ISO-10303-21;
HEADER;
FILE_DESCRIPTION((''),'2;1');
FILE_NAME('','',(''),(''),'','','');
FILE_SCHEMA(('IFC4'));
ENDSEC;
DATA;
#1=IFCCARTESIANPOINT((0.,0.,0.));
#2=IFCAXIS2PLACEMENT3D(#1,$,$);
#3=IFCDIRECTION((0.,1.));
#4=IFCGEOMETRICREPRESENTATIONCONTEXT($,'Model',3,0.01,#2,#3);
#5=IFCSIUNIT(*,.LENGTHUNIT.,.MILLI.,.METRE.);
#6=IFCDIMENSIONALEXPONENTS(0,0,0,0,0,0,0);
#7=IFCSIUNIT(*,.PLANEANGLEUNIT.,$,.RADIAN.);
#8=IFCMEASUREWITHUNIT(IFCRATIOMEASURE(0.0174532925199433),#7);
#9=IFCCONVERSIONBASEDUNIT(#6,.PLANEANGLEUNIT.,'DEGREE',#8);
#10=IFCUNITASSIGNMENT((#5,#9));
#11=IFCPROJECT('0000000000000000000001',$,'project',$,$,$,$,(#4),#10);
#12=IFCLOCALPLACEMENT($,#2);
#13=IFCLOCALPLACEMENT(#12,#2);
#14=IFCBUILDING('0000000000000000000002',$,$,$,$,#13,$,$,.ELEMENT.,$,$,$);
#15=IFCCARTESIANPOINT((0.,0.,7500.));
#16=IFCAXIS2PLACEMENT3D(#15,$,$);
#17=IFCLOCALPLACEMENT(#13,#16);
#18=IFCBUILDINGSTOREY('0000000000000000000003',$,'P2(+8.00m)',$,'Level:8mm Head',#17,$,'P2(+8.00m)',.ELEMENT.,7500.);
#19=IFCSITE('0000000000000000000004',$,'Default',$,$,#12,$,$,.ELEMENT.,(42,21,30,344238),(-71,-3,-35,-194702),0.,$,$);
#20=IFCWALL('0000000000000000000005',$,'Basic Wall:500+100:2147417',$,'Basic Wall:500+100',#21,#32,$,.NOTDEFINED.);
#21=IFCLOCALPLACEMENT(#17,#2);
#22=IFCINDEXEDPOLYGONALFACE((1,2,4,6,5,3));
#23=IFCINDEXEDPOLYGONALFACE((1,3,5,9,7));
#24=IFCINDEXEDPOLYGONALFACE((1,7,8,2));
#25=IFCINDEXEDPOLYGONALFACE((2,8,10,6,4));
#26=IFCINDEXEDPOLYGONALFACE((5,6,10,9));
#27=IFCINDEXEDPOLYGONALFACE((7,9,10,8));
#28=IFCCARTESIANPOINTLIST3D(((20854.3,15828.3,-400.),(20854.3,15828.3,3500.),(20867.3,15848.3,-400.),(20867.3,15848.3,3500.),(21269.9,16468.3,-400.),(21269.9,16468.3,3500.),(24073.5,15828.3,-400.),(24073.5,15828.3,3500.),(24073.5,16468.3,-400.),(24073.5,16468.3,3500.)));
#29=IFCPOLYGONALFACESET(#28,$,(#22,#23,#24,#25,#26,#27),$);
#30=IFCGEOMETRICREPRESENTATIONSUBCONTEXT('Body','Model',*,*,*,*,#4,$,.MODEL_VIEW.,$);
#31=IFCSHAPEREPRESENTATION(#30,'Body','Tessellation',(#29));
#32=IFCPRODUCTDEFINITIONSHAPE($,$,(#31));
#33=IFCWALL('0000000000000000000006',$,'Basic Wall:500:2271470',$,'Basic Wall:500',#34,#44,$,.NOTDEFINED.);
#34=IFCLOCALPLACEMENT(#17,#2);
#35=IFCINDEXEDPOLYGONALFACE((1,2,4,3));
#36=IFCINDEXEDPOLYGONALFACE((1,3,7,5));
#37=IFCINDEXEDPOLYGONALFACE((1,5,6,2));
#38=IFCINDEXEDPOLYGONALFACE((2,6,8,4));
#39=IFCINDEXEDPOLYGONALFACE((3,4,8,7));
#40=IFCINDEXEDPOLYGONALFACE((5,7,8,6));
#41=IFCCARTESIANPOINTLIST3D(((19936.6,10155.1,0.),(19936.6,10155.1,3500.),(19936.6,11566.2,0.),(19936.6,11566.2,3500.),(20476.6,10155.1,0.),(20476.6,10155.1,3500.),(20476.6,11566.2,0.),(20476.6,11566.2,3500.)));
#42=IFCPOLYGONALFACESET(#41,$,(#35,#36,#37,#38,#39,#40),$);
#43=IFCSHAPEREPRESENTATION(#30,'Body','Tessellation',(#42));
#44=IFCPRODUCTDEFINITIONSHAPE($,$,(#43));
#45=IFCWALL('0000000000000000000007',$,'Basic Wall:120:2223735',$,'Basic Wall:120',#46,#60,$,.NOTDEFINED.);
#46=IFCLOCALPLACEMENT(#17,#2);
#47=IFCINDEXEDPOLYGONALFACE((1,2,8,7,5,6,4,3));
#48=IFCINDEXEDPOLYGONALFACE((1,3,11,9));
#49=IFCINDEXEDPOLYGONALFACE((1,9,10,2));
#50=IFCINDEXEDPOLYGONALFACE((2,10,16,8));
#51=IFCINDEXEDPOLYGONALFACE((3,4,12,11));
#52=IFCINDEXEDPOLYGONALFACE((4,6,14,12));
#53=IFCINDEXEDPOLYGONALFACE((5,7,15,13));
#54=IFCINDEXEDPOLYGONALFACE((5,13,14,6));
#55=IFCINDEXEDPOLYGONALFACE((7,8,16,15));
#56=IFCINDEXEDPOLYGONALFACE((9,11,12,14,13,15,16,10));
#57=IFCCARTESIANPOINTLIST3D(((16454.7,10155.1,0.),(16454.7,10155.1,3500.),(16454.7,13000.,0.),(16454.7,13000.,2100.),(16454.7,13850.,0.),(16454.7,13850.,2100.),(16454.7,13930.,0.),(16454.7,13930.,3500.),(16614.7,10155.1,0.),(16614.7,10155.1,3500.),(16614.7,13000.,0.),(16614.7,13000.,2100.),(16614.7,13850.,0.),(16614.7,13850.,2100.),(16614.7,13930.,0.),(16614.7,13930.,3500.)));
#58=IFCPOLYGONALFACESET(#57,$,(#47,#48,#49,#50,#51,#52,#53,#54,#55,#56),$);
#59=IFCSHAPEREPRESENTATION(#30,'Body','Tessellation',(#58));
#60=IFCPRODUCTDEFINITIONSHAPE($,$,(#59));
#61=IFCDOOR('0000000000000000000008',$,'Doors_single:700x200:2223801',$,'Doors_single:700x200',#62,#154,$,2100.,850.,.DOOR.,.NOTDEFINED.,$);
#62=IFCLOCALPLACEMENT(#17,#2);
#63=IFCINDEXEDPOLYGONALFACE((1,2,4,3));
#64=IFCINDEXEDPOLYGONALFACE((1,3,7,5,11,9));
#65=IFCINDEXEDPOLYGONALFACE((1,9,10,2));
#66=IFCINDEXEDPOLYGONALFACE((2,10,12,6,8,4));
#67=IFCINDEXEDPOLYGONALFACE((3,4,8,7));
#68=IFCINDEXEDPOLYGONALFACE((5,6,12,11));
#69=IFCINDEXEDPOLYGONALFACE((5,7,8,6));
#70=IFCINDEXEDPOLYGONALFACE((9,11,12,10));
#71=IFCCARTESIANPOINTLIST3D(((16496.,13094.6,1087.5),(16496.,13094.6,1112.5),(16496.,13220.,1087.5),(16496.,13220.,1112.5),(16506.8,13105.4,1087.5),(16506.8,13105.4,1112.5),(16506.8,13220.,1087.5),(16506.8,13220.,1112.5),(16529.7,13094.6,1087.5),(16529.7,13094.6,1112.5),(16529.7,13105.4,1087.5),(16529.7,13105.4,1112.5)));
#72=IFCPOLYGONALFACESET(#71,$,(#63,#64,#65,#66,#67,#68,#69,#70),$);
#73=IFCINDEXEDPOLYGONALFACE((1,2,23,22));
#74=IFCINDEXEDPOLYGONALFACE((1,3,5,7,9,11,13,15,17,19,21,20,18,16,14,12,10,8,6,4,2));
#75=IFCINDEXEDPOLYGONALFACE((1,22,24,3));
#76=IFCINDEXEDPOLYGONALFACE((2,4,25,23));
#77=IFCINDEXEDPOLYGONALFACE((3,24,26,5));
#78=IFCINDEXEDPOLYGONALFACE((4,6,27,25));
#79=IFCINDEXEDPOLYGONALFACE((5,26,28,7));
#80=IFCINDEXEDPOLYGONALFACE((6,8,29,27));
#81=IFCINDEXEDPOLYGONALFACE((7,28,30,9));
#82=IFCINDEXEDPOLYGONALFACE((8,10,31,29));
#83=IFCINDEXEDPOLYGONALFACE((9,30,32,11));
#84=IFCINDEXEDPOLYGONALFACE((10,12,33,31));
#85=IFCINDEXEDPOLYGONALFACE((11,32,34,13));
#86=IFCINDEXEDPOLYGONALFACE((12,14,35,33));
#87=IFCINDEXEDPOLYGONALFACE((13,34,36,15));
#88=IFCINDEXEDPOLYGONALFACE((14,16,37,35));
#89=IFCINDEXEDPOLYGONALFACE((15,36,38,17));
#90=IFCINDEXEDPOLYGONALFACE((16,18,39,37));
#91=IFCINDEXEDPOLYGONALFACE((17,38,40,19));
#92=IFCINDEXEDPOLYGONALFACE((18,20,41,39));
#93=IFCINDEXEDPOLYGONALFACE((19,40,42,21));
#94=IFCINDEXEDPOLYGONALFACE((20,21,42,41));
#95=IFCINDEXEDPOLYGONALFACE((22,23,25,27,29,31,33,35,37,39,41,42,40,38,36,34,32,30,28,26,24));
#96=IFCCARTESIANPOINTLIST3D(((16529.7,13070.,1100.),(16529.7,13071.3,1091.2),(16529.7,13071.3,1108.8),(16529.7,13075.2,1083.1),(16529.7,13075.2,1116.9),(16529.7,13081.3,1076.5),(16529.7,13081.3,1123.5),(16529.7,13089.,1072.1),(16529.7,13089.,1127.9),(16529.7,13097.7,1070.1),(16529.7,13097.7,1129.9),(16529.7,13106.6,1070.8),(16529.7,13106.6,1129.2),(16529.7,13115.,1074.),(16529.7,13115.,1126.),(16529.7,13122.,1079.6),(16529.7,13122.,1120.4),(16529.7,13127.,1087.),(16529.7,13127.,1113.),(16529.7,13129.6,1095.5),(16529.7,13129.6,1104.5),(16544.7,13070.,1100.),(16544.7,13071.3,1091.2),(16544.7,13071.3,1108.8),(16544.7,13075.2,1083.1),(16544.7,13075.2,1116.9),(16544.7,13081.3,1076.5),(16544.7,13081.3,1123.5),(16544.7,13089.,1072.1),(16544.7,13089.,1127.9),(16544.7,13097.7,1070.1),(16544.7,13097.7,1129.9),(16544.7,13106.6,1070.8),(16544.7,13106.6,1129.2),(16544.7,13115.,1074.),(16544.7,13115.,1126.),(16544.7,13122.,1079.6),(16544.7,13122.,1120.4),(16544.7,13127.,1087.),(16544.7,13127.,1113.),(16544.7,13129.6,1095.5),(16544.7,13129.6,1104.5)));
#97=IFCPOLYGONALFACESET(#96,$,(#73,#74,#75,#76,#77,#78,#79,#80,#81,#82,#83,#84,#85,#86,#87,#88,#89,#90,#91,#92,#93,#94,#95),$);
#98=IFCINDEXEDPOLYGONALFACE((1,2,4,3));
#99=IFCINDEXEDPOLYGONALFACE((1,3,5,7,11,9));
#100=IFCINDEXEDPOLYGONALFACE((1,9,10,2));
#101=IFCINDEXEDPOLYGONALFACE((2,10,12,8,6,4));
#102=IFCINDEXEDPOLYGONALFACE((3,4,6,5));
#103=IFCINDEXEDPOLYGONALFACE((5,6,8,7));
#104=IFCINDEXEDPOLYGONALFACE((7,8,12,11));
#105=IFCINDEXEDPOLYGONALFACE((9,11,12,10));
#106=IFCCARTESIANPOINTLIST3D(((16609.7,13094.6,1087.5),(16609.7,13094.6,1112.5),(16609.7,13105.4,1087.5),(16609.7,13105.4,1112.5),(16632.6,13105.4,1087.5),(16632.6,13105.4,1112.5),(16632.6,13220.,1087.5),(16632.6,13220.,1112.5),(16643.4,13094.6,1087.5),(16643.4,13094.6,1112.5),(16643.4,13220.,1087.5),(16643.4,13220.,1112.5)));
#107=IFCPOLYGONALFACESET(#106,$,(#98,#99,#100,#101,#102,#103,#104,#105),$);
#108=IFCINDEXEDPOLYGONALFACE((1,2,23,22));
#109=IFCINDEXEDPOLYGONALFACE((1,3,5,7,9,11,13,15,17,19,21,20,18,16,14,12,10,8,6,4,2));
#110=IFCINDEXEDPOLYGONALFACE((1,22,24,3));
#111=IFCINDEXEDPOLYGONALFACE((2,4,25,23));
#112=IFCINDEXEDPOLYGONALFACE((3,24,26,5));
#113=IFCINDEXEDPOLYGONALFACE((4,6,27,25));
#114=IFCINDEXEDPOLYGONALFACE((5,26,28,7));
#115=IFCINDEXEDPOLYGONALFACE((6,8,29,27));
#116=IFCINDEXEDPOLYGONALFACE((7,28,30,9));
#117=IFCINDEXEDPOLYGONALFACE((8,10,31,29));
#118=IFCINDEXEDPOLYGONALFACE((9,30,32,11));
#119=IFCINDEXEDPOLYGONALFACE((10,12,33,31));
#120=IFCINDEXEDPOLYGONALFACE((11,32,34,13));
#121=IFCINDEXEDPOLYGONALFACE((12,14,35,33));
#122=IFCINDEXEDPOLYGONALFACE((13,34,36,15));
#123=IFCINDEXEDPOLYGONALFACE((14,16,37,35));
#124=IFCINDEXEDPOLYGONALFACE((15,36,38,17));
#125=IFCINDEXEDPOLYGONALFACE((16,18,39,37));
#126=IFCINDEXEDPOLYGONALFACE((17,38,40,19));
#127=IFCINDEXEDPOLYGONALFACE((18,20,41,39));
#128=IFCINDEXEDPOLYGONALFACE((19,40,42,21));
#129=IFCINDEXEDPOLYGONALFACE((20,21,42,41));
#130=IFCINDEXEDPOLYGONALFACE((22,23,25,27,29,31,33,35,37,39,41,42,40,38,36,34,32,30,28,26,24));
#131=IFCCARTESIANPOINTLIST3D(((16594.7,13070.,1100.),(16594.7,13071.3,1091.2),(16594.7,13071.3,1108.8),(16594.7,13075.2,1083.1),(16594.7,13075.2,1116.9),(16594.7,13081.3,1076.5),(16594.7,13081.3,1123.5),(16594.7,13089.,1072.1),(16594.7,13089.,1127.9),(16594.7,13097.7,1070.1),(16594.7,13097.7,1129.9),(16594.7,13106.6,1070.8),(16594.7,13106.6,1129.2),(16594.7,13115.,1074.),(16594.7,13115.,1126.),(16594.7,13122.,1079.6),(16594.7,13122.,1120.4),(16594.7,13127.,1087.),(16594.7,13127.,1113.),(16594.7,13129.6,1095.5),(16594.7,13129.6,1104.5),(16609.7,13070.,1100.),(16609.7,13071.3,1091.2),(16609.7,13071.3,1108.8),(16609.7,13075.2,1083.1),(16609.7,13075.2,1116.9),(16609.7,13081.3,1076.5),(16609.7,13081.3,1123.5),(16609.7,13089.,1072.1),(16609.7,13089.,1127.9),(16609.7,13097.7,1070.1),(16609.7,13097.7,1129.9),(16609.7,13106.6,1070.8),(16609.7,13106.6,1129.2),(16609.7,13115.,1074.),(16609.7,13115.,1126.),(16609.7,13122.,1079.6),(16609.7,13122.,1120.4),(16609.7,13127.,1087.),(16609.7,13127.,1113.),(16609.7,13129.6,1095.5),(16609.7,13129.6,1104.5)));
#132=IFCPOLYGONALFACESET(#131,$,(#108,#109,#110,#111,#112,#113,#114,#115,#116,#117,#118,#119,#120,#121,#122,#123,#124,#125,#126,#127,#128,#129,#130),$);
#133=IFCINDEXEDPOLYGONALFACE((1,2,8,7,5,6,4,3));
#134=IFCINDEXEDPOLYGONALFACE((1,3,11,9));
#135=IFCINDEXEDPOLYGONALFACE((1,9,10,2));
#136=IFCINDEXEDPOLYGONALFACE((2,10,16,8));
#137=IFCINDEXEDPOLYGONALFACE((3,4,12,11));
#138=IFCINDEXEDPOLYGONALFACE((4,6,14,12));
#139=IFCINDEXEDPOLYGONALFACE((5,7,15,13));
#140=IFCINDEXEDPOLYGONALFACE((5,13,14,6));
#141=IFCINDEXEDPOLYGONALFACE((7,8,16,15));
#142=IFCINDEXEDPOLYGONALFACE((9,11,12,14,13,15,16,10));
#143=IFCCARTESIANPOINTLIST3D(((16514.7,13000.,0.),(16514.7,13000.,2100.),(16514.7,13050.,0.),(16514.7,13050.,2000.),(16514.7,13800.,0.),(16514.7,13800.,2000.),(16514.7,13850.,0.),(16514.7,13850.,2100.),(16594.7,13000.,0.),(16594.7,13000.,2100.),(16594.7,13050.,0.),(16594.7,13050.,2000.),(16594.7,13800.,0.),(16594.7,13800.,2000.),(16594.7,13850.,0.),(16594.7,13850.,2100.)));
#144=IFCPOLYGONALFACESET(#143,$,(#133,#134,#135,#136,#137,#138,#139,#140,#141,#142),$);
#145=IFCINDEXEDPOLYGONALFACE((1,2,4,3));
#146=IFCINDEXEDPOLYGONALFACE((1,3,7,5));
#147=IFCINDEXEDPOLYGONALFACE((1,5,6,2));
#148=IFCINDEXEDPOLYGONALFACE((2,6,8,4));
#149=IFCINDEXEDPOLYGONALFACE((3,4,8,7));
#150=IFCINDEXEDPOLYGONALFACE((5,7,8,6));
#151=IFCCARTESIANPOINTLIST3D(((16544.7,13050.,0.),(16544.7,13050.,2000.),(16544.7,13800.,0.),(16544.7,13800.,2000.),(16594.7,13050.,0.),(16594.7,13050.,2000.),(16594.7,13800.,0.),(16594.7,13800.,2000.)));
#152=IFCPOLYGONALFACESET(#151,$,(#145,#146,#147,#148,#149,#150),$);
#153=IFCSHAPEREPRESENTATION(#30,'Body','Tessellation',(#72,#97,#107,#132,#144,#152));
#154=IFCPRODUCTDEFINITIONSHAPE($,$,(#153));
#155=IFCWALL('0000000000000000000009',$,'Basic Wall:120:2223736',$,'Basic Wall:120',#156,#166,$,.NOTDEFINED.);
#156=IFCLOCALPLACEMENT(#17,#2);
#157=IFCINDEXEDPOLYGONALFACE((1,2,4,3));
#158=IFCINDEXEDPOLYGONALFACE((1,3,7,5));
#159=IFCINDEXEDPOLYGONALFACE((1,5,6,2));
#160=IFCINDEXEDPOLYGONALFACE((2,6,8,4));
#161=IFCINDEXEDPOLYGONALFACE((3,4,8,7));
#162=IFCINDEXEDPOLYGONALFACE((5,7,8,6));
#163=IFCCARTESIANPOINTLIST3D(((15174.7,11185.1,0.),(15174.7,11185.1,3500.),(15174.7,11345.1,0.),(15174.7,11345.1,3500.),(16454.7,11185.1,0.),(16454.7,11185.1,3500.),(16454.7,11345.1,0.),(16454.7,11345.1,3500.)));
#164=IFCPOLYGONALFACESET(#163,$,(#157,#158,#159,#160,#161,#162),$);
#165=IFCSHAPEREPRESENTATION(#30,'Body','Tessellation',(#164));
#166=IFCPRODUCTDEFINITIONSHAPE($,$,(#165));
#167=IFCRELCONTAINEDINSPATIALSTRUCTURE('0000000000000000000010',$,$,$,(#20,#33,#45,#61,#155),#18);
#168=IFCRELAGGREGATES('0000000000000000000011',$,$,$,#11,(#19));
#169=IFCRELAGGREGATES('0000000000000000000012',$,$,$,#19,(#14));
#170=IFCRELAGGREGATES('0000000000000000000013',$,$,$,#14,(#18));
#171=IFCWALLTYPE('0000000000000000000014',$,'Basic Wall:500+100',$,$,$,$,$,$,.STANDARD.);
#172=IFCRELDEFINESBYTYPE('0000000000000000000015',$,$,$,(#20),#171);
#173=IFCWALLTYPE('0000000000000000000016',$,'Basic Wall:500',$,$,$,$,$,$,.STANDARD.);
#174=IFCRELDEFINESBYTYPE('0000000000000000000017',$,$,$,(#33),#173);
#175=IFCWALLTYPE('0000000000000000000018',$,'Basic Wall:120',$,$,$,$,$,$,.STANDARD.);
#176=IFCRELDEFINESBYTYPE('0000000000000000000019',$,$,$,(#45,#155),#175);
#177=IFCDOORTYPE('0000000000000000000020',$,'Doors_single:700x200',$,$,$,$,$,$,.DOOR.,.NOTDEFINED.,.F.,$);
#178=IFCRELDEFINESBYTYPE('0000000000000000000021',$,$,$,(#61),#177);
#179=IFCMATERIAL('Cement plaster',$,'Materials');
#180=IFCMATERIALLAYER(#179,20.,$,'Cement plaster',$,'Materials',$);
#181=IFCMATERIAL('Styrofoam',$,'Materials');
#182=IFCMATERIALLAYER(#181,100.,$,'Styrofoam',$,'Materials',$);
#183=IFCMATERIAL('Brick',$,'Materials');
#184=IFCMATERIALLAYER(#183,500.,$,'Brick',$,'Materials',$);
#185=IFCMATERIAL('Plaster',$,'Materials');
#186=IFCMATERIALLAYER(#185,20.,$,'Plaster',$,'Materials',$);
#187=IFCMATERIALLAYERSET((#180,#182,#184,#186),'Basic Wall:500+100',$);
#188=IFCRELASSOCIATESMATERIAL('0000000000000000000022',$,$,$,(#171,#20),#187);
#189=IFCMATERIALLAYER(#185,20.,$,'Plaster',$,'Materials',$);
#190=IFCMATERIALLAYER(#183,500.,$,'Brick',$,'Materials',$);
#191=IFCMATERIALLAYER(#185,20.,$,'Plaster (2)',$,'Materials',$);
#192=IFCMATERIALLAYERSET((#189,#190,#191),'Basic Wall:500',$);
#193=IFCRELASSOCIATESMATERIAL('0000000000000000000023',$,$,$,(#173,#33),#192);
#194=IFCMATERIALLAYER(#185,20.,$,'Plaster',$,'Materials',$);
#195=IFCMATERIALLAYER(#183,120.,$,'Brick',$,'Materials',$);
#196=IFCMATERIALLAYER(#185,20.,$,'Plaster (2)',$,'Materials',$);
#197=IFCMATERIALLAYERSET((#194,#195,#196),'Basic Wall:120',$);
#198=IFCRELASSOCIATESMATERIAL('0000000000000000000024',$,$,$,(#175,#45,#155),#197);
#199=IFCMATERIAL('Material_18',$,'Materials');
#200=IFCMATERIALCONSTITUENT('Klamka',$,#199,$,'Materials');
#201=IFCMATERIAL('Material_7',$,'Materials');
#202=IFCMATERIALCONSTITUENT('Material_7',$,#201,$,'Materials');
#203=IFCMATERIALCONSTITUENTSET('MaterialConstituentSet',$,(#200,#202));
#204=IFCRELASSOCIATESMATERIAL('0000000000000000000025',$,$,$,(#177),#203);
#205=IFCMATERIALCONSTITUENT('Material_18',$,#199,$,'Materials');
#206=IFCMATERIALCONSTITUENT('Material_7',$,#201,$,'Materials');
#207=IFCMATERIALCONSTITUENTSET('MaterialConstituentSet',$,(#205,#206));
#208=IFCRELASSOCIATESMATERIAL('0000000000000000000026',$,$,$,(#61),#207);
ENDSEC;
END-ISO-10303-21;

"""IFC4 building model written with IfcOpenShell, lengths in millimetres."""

from ifc_helpers import new_model, entity, si_unit, converted_unit, direction, frame, frame_2d, origin, origin_2d_with_axis, place, context, subcontext, project, spatial, polyline, rectangle, circle, outline, extrude, source, transform, mapped, material, layer, layer_set, layer_usage, constituent, constituent_set, type_object, type_shapes, element, fill, save


model = new_model("IFC4")

# Units and contexts
model_context = context("Model", 3, precision=0.01, world=origin(), true_north=direction((0.0, 1.0)))
body_context = subcontext(model_context, "Body", "Model", "MODEL_VIEW")
ifc_project = project(units=[si_unit("LENGTHUNIT", "METRE", prefix="MILLI"), converted_unit("PLANEANGLEUNIT", "DEGREE", entity("IfcRatioMeasure", 0.0174532925199433), si_unit("PLANEANGLEUNIT", "RADIAN"), dimensions=[0, 0, 0, 0, 0, 0, 0])], contexts=[model_context])

# Site, building, storey
site_placement = place(None, origin())
site = spatial("IfcSite", under=ifc_project, at=site_placement, Name="Default", CompositionType="ELEMENT", RefLatitude=(42, 21, 30, 344238), RefLongitude=(-71, -3, -35, -194702), RefElevation=0.0)
building_placement = place(site_placement, origin())
building = spatial("IfcBuilding", under=site, at=building_placement, CompositionType="ELEMENT")
storey_placement = place(building_placement, frame((0.0, 0.0, 7500.0)))
storey = spatial("IfcBuildingStorey", under=building, at=storey_placement, Name="P2(+8.00m)", ObjectType="Level:8mm Head", LongName="P2(+8.00m)", CompositionType="ELEMENT", Elevation=7500.0)

# Wall
ifc_material_1 = material(Name="Cement plaster", Category="Materials")
ifc_layer_1 = layer(ifc_material_1, 20.0, Name="Cement plaster", Category="Materials")
ifc_material_2 = material(Name="Styrofoam", Category="Materials")
ifc_layer_2 = layer(ifc_material_2, 100.0, Name="Styrofoam", Category="Materials")
ifc_material_3 = material(Name="Brick", Category="Materials")
ifc_layer_3 = layer(ifc_material_3, 500.0, Name="Brick", Category="Materials")
ifc_material_4 = material(Name="Plaster", Category="Materials")
ifc_layer_4 = layer(ifc_material_4, 20.0, Name="Plaster", Category="Materials")
ifc_layer_set_1 = layer_set([ifc_layer_1, ifc_layer_2, ifc_layer_3, ifc_layer_4], Name="Basic Wall:500+100")
ifc_layer_usage_1 = layer_usage(ifc_layer_set_1, "AXIS2", "POSITIVE", -320.0)
wall_type_1 = type_object("IfcWallType", Name="Basic Wall:500+100", PredefinedType="STANDARD", material=ifc_layer_set_1)
wall_1_placement = place(storey_placement, frame((24073.5, 16148.3, -400.0), z_axis=(0.0, 0.0, 1.0), x_axis=(-1.0, 0.0, 0.0)))
element("IfcWall", 1, at=wall_1_placement, inside=storey, type_object=wall_type_1, material=ifc_layer_usage_1, Name="Basic Wall:500+100:2147417", ObjectType="Basic Wall:500+100", PredefinedType="NOTDEFINED", context=body_context, shape_type="SweptSolid", body=[
    extrude(outline(polyline([(2803.6, -320.0), (3206.2, 300.0), (3219.2, 320.0), (0.0, 320.0), (0.0, -320.0), (2803.6, -320.0)])), origin(), (0.0, 0.0, 1.0), 3900.0),
])

# Shared definitions
ifc_layer_5 = layer(ifc_material_4, 20.0, Name="Plaster", Category="Materials")
ifc_layer_6 = layer(ifc_material_3, 500.0, Name="Brick", Category="Materials")
ifc_layer_7 = layer(ifc_material_4, 20.0, Name="Plaster (2)", Category="Materials")
ifc_layer_set_2 = layer_set([ifc_layer_5, ifc_layer_6, ifc_layer_7], Name="Basic Wall:500")
wall_type_2 = type_object("IfcWallType", Name="Basic Wall:500", PredefinedType="STANDARD", material=ifc_layer_set_2)
ifc_material_5 = material(Name="Material_18", Category="Materials")
ifc_material_6 = material(Name="Material_7", Category="Materials")

# Wall
ifc_layer_usage_2 = layer_usage(ifc_layer_set_2, "AXIS2", "NEGATIVE", 270.0)
wall_2_placement = place(storey_placement, frame((20206.6, 11566.2, 0.0), z_axis=(0.0, 0.0, 1.0), x_axis=(0.0, -1.0, 0.0)))
element("IfcWall", 2, at=wall_2_placement, inside=storey, type_object=wall_type_2, material=ifc_layer_usage_2, Name="Basic Wall:500:2271470", ObjectType="Basic Wall:500", PredefinedType="NOTDEFINED", context=body_context, shape_type="SweptSolid", body=[
    extrude(rectangle(XDim=1411.2, YDim=540.0, at=frame_2d((705.6, 0.0), x_axis=(-1.0, 0.0))), origin(), (0.0, 0.0, 1.0), 3500.0),
])

# Wall, opening, door
ifc_layer_8 = layer(ifc_material_4, 20.0, Name="Plaster", Category="Materials")
ifc_layer_9 = layer(ifc_material_3, 120.0, Name="Brick", Category="Materials")
ifc_layer_10 = layer(ifc_material_4, 20.0, Name="Plaster (2)", Category="Materials")
ifc_layer_set_3 = layer_set([ifc_layer_8, ifc_layer_9, ifc_layer_10], Name="Basic Wall:120")
ifc_layer_usage_3 = layer_usage(ifc_layer_set_3, "AXIS2", "POSITIVE", -80.0)
wall_type_3 = type_object("IfcWallType", Name="Basic Wall:120", PredefinedType="STANDARD", material=ifc_layer_set_3)
wall_3_placement = place(storey_placement, frame((16534.7, 10155.1, 0.0), z_axis=(0.0, 0.0, 1.0), x_axis=(0.0, 1.0, 0.0)))
wall_3 = element("IfcWall", 3, at=wall_3_placement, inside=storey, type_object=wall_type_3, material=ifc_layer_usage_3, Name="Basic Wall:120:2223735", ObjectType="Basic Wall:120", PredefinedType="NOTDEFINED", context=body_context, shape_type="SweptSolid", body=[
    extrude(rectangle(XDim=3774.9, YDim=160.0, at=frame_2d((1887.5, 0.0), x_axis=(-1.0, 0.0))), origin(), (0.0, 0.0, 1.0), 3500.0),
])
opening_1_placement = place(wall_3_placement, frame((3694.9, 80.0, 0.0)))
opening_1 = element("IfcOpeningElement", 4, at=opening_1_placement, cuts=wall_3, PredefinedType="OPENING", context=body_context, shape_type="SweptSolid", body=[
    extrude(rectangle(XDim=2100.0, YDim=850.0, at=frame_2d((1050.0, 425.0), x_axis=(1.0, 0.0))), frame((0.0, 0.0, 0.0), z_axis=(0.0, -1.0, 0.0), x_axis=(0.0, 0.0, 1.0)), (0.0, 0.0, 1.0), 160.0),
])
ifc_constituent_1 = constituent(ifc_material_5, Name="Material_18", Category="Materials")
ifc_constituent_2 = constituent(ifc_material_6, Name="Material_7", Category="Materials")
ifc_constituent_set_1 = constituent_set(constituents=[ifc_constituent_1, ifc_constituent_2], Name="MaterialConstituentSet")
ifc_constituent_3 = constituent(ifc_material_5, Name="Klamka", Category="Materials")
ifc_constituent_4 = constituent(ifc_material_6, Name="Material_7", Category="Materials")
ifc_constituent_set_2 = constituent_set(constituents=[ifc_constituent_3, ifc_constituent_4], Name="MaterialConstituentSet")
door_type_1 = type_object("IfcDoorType", Name="Doors_single:700x200", OperationType="NOTDEFINED", ParameterTakesPrecedence=False, PredefinedType="DOOR", material=ifc_constituent_set_2)
shared_shape_1 = source(origin(), body_context, "Body", "SweptSolid", [
    extrude(outline(polyline([(-45.4, -18.9), (-34.6, -18.9), (-34.6, 4.0), (80.0, 4.0), (80.0, 14.8), (-45.4, 14.8), (-45.4, -18.9)])), frame((710.0, 56.1, 1087.5), z_axis=(0.0, 0.0, 1.0), x_axis=(-1.0, 0.0, 0.0)), (0.0, 0.0, 1.0), 25.0),
    extrude(circle(Radius=30.0, at=frame_2d((0.0, 0.0), x_axis=(1.0, 0.0))), frame((750.0, 75.0, 1100.0), z_axis=(0.0, 1.0, 0.0), x_axis=(1.0, 0.0, 0.0)), (0.0, 0.0, 1.0), 15.0),
    extrude(outline(polyline([(-18.9, -45.4), (14.8, -45.4), (14.8, 80.0), (4.0, 80.0), (4.0, -34.6), (-18.9, -34.6), (-18.9, -45.4)])), frame((710.0, 173.9, 1087.5), z_axis=(0.0, 0.0, 1.0), x_axis=(0.0, 1.0, 0.0)), (0.0, 0.0, 1.0), 25.0),
    extrude(circle(Radius=30.0, at=frame_2d((0.0, 0.0), x_axis=(1.0, 0.0))), frame((750.0, 140.0, 1100.0), z_axis=(0.0, 1.0, 0.0), x_axis=(1.0, 0.0, 0.0)), (0.0, 0.0, 1.0), 15.0),
    extrude(outline(polyline([(-425.0, -1025.0), (-375.0, -1025.0), (-375.0, 975.0), (375.0, 975.0), (375.0, -1025.0), (425.0, -1025.0), (425.0, 1075.0), (-425.0, 1075.0), (-425.0, -1025.0)])), frame((425.0, 60.0, 1025.0), z_axis=(0.0, 1.0, 0.0), x_axis=(-1.0, 0.0, 0.0)), (0.0, 0.0, 1.0), 80.0),
    extrude(rectangle(XDim=750.0, YDim=50.0, at=origin_2d_with_axis()), frame((425.0, 115.0, 0.0), z_axis=(0.0, 0.0, 1.0), x_axis=(-1.0, 0.0, 0.0)), (0.0, 0.0, 1.0), 2000.0),
])
type_shapes(door_type_1, [shared_shape_1])
door_1_placement = place(opening_1_placement, frame((0.0, 0.0, 0.0), z_axis=(0.0, 0.0, 1.0), x_axis=(-1.0, 0.0, 0.0)))
door_1 = element("IfcDoor", 5, at=door_1_placement, inside=storey, type_object=door_type_1, material=ifc_constituent_set_1, Name="Doors_single:700x200:2223801", ObjectType="Doors_single:700x200", OperationType="NOTDEFINED", OverallHeight=2100.0, OverallWidth=850.0, PredefinedType="DOOR", context=body_context, shape_type="MappedRepresentation", body=[
    mapped(shared_shape_1, transform((0.0, 0.0, 0.0), scale=1.0)),
])
fill(opening_1, door_1)

# Wall
ifc_layer_usage_4 = layer_usage(ifc_layer_set_3, "AXIS2", "POSITIVE", -80.0)
wall_4_placement = place(storey_placement, frame((16454.7, 11265.1, 0.0), z_axis=(0.0, 0.0, 1.0), x_axis=(-1.0, 0.0, 0.0)))
element("IfcWall", 6, at=wall_4_placement, inside=storey, type_object=wall_type_3, material=ifc_layer_usage_4, Name="Basic Wall:120:2223736", ObjectType="Basic Wall:120", PredefinedType="NOTDEFINED", context=body_context, shape_type="SweptSolid", body=[
    extrude(rectangle(XDim=1280.0, YDim=160.0, at=frame_2d((640.0, 0.0), x_axis=(-1.0, 0.0))), origin(), (0.0, 0.0, 1.0), 3500.0),
])

save(model, "model.ifc")
